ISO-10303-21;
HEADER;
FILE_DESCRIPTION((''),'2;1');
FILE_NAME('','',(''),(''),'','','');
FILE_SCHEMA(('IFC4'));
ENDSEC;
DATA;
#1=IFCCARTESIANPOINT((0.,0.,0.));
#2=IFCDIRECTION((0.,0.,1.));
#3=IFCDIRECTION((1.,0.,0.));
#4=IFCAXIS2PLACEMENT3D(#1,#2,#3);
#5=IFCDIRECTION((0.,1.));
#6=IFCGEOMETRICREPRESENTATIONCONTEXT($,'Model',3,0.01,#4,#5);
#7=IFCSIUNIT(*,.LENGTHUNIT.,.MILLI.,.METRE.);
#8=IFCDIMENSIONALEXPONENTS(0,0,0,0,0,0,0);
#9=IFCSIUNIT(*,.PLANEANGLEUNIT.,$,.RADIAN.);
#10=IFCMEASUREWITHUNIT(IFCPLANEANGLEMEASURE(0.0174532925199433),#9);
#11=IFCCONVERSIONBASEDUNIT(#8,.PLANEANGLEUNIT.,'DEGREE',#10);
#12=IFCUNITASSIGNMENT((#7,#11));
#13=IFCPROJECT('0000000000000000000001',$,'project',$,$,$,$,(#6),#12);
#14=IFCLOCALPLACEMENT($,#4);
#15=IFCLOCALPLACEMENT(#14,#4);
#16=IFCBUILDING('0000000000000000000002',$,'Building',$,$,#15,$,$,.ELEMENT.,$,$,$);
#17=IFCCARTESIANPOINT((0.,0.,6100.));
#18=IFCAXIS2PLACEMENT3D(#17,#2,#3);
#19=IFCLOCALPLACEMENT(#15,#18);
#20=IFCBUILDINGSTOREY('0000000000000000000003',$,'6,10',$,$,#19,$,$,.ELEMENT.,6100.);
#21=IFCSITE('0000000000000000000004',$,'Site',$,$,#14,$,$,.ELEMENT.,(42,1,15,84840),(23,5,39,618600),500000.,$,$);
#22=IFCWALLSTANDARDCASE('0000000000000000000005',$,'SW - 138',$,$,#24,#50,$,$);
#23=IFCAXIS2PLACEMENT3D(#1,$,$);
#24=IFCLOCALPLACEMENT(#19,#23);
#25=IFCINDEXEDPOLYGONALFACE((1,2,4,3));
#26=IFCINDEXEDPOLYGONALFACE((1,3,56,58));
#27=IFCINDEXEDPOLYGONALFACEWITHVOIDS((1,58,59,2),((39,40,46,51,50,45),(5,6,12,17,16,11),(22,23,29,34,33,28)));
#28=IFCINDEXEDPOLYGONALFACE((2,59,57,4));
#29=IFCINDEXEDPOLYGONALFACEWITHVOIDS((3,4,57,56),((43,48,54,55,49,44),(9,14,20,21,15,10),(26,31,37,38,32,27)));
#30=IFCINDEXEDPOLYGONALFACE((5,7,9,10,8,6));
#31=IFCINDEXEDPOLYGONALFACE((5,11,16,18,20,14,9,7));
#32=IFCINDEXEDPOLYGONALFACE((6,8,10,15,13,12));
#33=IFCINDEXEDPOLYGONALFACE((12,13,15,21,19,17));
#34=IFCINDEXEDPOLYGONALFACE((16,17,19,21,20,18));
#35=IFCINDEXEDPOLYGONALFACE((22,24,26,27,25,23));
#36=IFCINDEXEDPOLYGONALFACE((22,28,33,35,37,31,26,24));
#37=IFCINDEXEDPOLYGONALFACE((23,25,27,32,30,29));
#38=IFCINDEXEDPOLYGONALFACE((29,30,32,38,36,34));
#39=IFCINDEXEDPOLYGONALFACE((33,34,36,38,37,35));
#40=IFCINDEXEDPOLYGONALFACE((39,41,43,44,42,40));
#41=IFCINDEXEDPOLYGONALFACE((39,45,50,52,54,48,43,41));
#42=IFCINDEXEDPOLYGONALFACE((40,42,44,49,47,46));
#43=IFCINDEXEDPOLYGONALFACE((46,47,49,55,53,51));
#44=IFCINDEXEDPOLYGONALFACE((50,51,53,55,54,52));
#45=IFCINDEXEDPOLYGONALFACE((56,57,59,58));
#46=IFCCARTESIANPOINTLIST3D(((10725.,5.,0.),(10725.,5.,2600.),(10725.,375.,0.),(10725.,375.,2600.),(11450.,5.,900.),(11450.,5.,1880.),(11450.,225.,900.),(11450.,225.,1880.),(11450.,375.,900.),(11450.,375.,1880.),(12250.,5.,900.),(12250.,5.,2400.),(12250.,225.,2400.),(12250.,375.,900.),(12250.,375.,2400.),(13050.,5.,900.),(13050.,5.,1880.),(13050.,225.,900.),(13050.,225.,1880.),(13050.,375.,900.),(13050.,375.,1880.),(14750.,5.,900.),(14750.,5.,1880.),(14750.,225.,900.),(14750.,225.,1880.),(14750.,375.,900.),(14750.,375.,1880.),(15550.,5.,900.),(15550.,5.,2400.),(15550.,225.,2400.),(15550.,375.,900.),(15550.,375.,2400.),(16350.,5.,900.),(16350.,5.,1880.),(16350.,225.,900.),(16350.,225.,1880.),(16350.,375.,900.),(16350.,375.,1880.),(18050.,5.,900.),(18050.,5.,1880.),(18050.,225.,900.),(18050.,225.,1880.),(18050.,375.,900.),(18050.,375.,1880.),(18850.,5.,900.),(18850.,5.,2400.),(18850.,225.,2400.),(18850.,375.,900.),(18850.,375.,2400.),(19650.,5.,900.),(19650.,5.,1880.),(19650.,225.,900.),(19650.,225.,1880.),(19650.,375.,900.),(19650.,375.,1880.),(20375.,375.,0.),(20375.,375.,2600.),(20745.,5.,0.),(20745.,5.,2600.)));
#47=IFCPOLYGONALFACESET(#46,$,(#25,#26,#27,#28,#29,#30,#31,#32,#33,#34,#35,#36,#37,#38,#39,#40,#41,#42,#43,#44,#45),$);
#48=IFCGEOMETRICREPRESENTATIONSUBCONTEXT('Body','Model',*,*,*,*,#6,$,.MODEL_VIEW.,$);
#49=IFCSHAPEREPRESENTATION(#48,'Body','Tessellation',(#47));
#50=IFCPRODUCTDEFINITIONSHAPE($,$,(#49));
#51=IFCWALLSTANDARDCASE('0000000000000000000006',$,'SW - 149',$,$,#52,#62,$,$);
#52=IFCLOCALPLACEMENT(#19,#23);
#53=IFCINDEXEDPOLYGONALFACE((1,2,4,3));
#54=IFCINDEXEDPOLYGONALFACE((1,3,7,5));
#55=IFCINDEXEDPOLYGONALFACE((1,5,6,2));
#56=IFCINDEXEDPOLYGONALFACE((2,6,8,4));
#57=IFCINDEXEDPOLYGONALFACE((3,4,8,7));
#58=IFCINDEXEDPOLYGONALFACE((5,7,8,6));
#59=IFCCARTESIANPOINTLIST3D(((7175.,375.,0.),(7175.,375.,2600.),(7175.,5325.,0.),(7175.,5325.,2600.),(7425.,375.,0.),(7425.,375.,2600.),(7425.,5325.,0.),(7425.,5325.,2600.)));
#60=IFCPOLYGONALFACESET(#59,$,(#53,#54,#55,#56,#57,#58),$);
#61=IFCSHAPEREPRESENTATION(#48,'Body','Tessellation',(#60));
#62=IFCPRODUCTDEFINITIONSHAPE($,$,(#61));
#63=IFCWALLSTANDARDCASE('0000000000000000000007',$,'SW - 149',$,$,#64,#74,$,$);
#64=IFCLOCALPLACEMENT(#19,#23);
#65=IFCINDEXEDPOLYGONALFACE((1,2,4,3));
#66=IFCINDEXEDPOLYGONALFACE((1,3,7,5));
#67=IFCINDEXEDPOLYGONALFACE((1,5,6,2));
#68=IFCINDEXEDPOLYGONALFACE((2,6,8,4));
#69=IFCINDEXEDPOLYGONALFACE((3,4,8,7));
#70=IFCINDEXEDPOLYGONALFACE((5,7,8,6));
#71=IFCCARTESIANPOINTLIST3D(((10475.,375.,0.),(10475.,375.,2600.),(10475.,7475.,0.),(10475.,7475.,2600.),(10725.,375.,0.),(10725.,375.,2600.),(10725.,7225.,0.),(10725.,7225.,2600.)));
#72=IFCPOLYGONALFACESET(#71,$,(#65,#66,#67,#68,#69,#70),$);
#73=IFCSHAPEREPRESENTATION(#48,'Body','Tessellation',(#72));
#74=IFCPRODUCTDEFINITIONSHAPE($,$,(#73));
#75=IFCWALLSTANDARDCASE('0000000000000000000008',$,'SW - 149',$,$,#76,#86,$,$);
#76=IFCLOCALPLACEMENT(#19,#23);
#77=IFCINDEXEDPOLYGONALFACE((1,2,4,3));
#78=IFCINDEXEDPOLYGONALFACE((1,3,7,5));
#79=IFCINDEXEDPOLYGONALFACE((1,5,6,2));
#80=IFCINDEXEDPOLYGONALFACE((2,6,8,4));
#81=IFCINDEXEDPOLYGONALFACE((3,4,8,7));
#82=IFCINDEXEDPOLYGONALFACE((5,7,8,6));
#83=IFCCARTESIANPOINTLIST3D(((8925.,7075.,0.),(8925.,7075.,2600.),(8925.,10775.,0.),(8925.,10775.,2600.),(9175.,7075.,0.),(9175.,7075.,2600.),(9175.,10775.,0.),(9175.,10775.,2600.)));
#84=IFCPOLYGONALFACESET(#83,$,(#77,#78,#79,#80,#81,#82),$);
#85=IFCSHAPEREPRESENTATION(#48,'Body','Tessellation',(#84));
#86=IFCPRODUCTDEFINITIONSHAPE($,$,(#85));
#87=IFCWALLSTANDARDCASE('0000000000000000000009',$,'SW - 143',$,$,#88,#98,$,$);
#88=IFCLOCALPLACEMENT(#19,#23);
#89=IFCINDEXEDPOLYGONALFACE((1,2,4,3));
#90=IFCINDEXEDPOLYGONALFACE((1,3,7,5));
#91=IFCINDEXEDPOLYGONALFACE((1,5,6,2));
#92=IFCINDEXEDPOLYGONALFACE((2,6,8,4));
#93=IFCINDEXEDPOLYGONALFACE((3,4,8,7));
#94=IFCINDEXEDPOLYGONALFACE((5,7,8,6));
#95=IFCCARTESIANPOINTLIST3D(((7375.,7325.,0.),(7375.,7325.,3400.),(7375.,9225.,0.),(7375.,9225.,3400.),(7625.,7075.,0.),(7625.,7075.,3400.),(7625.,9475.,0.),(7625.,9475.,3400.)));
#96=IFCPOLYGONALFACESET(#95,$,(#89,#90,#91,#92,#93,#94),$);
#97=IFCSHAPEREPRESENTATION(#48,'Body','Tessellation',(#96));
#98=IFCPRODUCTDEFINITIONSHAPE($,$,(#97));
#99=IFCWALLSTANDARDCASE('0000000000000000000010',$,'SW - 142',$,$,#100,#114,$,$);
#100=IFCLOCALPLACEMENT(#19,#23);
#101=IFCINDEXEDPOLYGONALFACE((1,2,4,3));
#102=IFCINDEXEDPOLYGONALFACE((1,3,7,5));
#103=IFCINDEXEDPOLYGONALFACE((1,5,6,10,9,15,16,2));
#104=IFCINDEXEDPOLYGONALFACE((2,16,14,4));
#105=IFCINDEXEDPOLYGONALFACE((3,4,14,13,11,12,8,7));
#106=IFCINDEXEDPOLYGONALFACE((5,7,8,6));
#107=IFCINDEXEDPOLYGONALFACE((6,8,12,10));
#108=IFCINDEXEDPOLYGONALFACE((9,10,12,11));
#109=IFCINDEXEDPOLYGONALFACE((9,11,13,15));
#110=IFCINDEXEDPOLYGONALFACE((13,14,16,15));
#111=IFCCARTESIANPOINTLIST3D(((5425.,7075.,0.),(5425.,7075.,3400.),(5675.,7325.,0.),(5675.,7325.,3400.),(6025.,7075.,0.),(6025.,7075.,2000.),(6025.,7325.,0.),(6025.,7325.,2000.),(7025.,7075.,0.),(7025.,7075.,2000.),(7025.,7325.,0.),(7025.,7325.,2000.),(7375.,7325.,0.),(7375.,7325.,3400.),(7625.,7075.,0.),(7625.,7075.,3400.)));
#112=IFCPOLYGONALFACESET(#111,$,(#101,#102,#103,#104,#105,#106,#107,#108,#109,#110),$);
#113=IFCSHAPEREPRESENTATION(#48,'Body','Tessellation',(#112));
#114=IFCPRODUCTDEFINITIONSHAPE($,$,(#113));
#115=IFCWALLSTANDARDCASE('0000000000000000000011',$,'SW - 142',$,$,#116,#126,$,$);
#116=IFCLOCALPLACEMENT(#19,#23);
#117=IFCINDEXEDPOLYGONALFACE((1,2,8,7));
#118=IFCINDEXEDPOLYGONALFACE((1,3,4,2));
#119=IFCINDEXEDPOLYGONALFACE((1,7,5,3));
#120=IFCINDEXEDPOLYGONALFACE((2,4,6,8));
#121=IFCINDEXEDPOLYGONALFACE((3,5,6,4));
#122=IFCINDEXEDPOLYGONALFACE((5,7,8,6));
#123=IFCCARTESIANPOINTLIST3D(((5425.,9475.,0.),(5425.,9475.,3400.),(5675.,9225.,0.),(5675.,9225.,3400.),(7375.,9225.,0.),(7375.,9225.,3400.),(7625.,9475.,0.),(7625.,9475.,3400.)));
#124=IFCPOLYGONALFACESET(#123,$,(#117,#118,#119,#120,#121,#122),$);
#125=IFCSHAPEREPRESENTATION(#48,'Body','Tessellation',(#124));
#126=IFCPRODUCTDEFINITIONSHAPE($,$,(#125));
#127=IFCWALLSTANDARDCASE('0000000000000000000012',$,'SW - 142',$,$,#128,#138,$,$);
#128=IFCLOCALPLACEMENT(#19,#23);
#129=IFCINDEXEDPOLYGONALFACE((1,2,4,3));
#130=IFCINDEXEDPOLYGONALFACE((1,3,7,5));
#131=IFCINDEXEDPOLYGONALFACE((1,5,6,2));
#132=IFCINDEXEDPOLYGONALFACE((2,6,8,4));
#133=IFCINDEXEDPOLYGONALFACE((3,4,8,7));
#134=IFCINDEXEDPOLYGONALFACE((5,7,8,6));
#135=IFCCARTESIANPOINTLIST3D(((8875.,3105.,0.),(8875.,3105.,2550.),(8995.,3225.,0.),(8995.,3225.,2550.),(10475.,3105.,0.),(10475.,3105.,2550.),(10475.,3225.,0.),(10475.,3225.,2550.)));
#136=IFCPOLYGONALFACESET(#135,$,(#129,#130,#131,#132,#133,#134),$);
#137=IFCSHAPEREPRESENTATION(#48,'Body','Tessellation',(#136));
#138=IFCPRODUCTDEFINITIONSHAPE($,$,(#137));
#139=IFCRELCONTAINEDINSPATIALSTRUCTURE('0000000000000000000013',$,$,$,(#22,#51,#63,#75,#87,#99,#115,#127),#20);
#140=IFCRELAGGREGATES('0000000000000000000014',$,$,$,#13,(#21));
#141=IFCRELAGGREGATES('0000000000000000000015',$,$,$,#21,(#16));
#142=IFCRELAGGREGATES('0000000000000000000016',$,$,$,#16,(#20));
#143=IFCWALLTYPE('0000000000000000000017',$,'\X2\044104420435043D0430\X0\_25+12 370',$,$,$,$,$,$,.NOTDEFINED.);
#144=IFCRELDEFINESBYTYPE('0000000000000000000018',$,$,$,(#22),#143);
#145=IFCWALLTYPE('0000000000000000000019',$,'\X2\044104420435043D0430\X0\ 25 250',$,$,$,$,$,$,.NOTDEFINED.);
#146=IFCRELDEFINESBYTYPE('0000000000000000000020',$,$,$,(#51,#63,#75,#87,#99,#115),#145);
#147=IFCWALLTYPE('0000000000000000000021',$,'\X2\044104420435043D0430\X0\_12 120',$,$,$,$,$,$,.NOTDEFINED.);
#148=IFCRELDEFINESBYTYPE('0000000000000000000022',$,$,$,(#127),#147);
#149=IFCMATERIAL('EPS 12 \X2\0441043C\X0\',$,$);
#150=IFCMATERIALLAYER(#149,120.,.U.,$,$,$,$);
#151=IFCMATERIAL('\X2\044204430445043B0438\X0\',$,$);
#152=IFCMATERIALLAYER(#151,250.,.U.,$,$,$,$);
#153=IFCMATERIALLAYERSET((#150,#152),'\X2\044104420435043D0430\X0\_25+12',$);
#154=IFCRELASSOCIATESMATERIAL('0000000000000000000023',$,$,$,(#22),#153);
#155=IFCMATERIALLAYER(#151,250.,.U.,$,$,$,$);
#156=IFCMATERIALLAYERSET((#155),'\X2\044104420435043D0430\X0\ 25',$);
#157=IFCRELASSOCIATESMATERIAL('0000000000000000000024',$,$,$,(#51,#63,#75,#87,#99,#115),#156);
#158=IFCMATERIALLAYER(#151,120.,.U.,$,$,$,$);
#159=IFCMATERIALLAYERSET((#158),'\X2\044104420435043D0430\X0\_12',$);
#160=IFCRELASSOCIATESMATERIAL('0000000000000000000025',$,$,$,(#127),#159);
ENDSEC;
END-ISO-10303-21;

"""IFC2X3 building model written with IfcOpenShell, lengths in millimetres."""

from ifc_helpers import new_model, entity, si_unit, converted_unit, direction, frame, origin_with_axes, origin_2d_with_axis, place, context, subcontext, project, spatial, polyline, rectangle, outline, extrude, material, layer, layer_set, layer_usage, type_object, element, save


model = new_model("IFC2X3")

# Units and contexts
model_context = context("Model", 3, precision=0.01, world=origin_with_axes(), true_north=direction((0.0, 1.0)))
body_context = subcontext(model_context, "Body", "Model", "MODEL_VIEW")
ifc_project = project(units=[si_unit("LENGTHUNIT", "METRE", prefix="MILLI"), converted_unit("PLANEANGLEUNIT", "DEGREE", entity("IfcPlaneAngleMeasure", 0.0174532925199433), si_unit("PLANEANGLEUNIT", "RADIAN"), dimensions=[0, 0, 0, 0, 0, 0, 0])], contexts=[model_context])

# Site, building, storey
site_placement = place(None, origin_with_axes())
site = spatial("IfcSite", under=ifc_project, at=site_placement, Name="Site", CompositionType="ELEMENT", RefLatitude=(42, 1, 15, 84840), RefLongitude=(23, 5, 39, 618600), RefElevation=500000.0)
building_placement = place(site_placement, origin_with_axes())
building = spatial("IfcBuilding", under=site, at=building_placement, Name="Building", CompositionType="ELEMENT")
storey_placement = place(building_placement, frame((0.0, 0.0, 6100.0), z_axis=(0.0, 0.0, 1.0), x_axis=(1.0, 0.0, 0.0)))
storey = spatial("IfcBuildingStorey", under=building, at=storey_placement, Name="6,10", CompositionType="ELEMENT", Elevation=6100.0)

# Wall, openings
ifc_material_1 = material(Name="EPS 12 см")
ifc_layer_1 = layer(ifc_material_1, 120.0, ventilated="UNKNOWN")
ifc_material_2 = material(Name="тухли")
ifc_layer_2 = layer(ifc_material_2, 250.0, ventilated="UNKNOWN")
ifc_layer_set_1 = layer_set([ifc_layer_1, ifc_layer_2], Name="стена_25+12")
ifc_layer_usage_1 = layer_usage(ifc_layer_set_1, "AXIS2", "POSITIVE", -120.0)
wall_type_1 = type_object("IfcWallType", Name="стена_25+12 370", PredefinedType="NOTDEFINED")
wall_1_placement = place(storey_placement, frame((10725.0, 125.0, 0.0), z_axis=(0.0, 0.0, 1.0), x_axis=(1.0, 0.0, 0.0)))
wall_1 = element("IfcWallStandardCase", 1, at=wall_1_placement, inside=storey, type_object=wall_type_1, material=ifc_layer_usage_1, Name="SW - 138", context=body_context, shape_type="SweptSolid", body=[
    extrude(outline(polyline([(0.0, -120.0), (10020.0, -120.0), (9650.0, 250.0), (0.0, 250.0), (0.0, -120.0)])), origin_with_axes(), (0.0, 0.0, 1.0), 2600.0),
])
opening_1_placement = place(wall_1_placement, frame((1925.0, 0.0, 900.0), z_axis=(0.0, 0.0, 1.0), x_axis=(1.0, 0.0, 0.0)))
element("IfcOpeningElement", 2, at=opening_1_placement, cuts=wall_1, context=body_context, shape_type="SweptSolid", body=[
    extrude(outline(polyline([(-400.0, 0.0), (-400.0, -1500.0), (400.0, -980.0), (400.0, 0.0), (-400.0, 0.0)])), frame((0.0, 100.0, 0.0), z_axis=(0.0, 1.0, 0.0), x_axis=(1.0, 0.0, 0.0)), (0.0, 0.0, -1.0), 590.0),
    extrude(outline(polyline([(400.0, 0.0), (400.0, 980.0), (-400.0, 1500.0), (-400.0, 0.0), (400.0, 0.0)])), frame((0.0, 100.0, 0.0), z_axis=(0.0, -1.0, 0.0), x_axis=(1.0, 0.0, 0.0)), (0.0, 0.0, -1.0), 520.0),
])
opening_2_placement = place(wall_1_placement, frame((5225.0, 0.0, 900.0), z_axis=(0.0, 0.0, 1.0), x_axis=(1.0, 0.0, 0.0)))
element("IfcOpeningElement", 3, at=opening_2_placement, cuts=wall_1, context=body_context, shape_type="SweptSolid", body=[
    extrude(outline(polyline([(-400.0, 0.0), (-400.0, -1500.0), (400.0, -980.0), (400.0, 0.0), (-400.0, 0.0)])), frame((0.0, 100.0, 0.0), z_axis=(0.0, 1.0, 0.0), x_axis=(1.0, 0.0, 0.0)), (0.0, 0.0, -1.0), 590.0),
    extrude(outline(polyline([(400.0, 0.0), (400.0, 980.0), (-400.0, 1500.0), (-400.0, 0.0), (400.0, 0.0)])), frame((0.0, 100.0, 0.0), z_axis=(0.0, -1.0, 0.0), x_axis=(1.0, 0.0, 0.0)), (0.0, 0.0, -1.0), 520.0),
])
opening_3_placement = place(wall_1_placement, frame((1125.0, 0.0, 900.0), z_axis=(0.0, 0.0, 1.0), x_axis=(1.0, 0.0, 0.0)))
element("IfcOpeningElement", 4, at=opening_3_placement, cuts=wall_1, context=body_context, shape_type="SweptSolid", body=[
    extrude(outline(polyline([(-400.0, 0.0), (-400.0, -1500.0), (400.0, -980.0), (400.0, 0.0), (-400.0, 0.0)])), frame((0.0, 100.0, 0.0), z_axis=(0.0, -1.0, 0.0), x_axis=(-1.0, 0.0, 0.0)), (0.0, 0.0, 1.0), 590.0),
    extrude(outline(polyline([(400.0, 0.0), (400.0, 980.0), (-400.0, 1500.0), (-400.0, 0.0), (400.0, 0.0)])), frame((0.0, 100.0, 0.0), z_axis=(0.0, 1.0, 0.0), x_axis=(-1.0, 0.0, 0.0)), (0.0, 0.0, 1.0), 520.0),
])
opening_4_placement = place(wall_1_placement, frame((4425.0, 0.0, 900.0), z_axis=(0.0, 0.0, 1.0), x_axis=(1.0, 0.0, 0.0)))
element("IfcOpeningElement", 5, at=opening_4_placement, cuts=wall_1, context=body_context, shape_type="SweptSolid", body=[
    extrude(outline(polyline([(-400.0, 0.0), (-400.0, -1500.0), (400.0, -980.0), (400.0, 0.0), (-400.0, 0.0)])), frame((0.0, 100.0, 0.0), z_axis=(0.0, -1.0, 0.0), x_axis=(-1.0, 0.0, 0.0)), (0.0, 0.0, 1.0), 590.0),
    extrude(outline(polyline([(400.0, 0.0), (400.0, 980.0), (-400.0, 1500.0), (-400.0, 0.0), (400.0, 0.0)])), frame((0.0, 100.0, 0.0), z_axis=(0.0, 1.0, 0.0), x_axis=(-1.0, 0.0, 0.0)), (0.0, 0.0, 1.0), 520.0),
])
opening_5_placement = place(wall_1_placement, frame((8525.0, 0.0, 900.0), z_axis=(0.0, 0.0, 1.0), x_axis=(1.0, 0.0, 0.0)))
element("IfcOpeningElement", 6, at=opening_5_placement, cuts=wall_1, context=body_context, shape_type="SweptSolid", body=[
    extrude(outline(polyline([(-400.0, 0.0), (-400.0, -1500.0), (400.0, -980.0), (400.0, 0.0), (-400.0, 0.0)])), frame((0.0, 100.0, 0.0), z_axis=(0.0, 1.0, 0.0), x_axis=(1.0, 0.0, 0.0)), (0.0, 0.0, -1.0), 590.0),
    extrude(outline(polyline([(400.0, 0.0), (400.0, 980.0), (-400.0, 1500.0), (-400.0, 0.0), (400.0, 0.0)])), frame((0.0, 100.0, 0.0), z_axis=(0.0, -1.0, 0.0), x_axis=(1.0, 0.0, 0.0)), (0.0, 0.0, -1.0), 520.0),
])
opening_6_placement = place(wall_1_placement, frame((7725.0, 0.0, 900.0), z_axis=(0.0, 0.0, 1.0), x_axis=(1.0, 0.0, 0.0)))
element("IfcOpeningElement", 7, at=opening_6_placement, cuts=wall_1, context=body_context, shape_type="SweptSolid", body=[
    extrude(outline(polyline([(-400.0, 0.0), (-400.0, -1500.0), (400.0, -980.0), (400.0, 0.0), (-400.0, 0.0)])), frame((0.0, 100.0, 0.0), z_axis=(0.0, -1.0, 0.0), x_axis=(-1.0, 0.0, 0.0)), (0.0, 0.0, 1.0), 590.0),
    extrude(outline(polyline([(400.0, 0.0), (400.0, 980.0), (-400.0, 1500.0), (-400.0, 0.0), (400.0, 0.0)])), frame((0.0, 100.0, 0.0), z_axis=(0.0, 1.0, 0.0), x_axis=(-1.0, 0.0, 0.0)), (0.0, 0.0, 1.0), 520.0),
])

# Walls
ifc_layer_3 = layer(ifc_material_2, 250.0, ventilated="UNKNOWN")
ifc_layer_set_2 = layer_set([ifc_layer_3], Name="стена 25")
ifc_layer_usage_2 = layer_usage(ifc_layer_set_2, "AXIS2", "NEGATIVE", 0.0)
wall_type_2 = type_object("IfcWallType", Name="стена 25 250", PredefinedType="NOTDEFINED")
wall_2_placement = place(storey_placement, frame((7175.0, 125.0, 0.0), z_axis=(0.0, 0.0, 1.0), x_axis=(0.0, 1.0, 0.0)))
element("IfcWallStandardCase", 8, at=wall_2_placement, inside=storey, type_object=wall_type_2, material=ifc_layer_usage_2, Name="SW - 149", context=body_context, shape_type="SweptSolid", body=[
    extrude(outline(polyline([(250.0, -250.0), (5200.0, -250.0), (5200.0, 0.0), (250.0, 0.0), (250.0, -250.0)])), origin_with_axes(), (0.0, 0.0, 1.0), 2600.0),
])
ifc_layer_usage_3 = layer_usage(ifc_layer_set_2, "AXIS2", "NEGATIVE", 0.0)
wall_3_placement = place(storey_placement, frame((10475.0, 125.0, 0.0), z_axis=(0.0, 0.0, 1.0), x_axis=(0.0, 1.0, 0.0)))
element("IfcWallStandardCase", 9, at=wall_3_placement, inside=storey, type_object=wall_type_2, material=ifc_layer_usage_3, Name="SW - 149", context=body_context, shape_type="SweptSolid", body=[
    extrude(outline(polyline([(250.0, -250.0), (7100.0, -250.0), (7350.0, 0.0), (250.0, 0.0), (250.0, -250.0)])), origin_with_axes(), (0.0, 0.0, 1.0), 2600.0),
])
ifc_layer_usage_4 = layer_usage(ifc_layer_set_2, "AXIS2", "NEGATIVE", 0.0)
wall_4_placement = place(storey_placement, frame((8925.0, 7075.0, 0.0), z_axis=(0.0, 0.0, 1.0), x_axis=(0.0, 1.0, 0.0)))
element("IfcWallStandardCase", 10, at=wall_4_placement, inside=storey, type_object=wall_type_2, material=ifc_layer_usage_4, Name="SW - 149", context=body_context, shape_type="SweptSolid", body=[
    extrude(outline(polyline([(0.0, -250.0), (3700.0, -250.0), (3700.0, 0.0), (0.0, 0.0), (0.0, -250.0)])), origin_with_axes(), (0.0, 0.0, 1.0), 2600.0),
])
ifc_layer_usage_5 = layer_usage(ifc_layer_set_2, "AXIS2", "NEGATIVE", 0.0)
wall_5_placement = place(storey_placement, frame((7625.0, 9475.0, 0.0), z_axis=(0.0, 0.0, 1.0), x_axis=(0.0, -1.0, 0.0)))
element("IfcWallStandardCase", 11, at=wall_5_placement, inside=storey, type_object=wall_type_2, material=ifc_layer_usage_5, Name="SW - 143", context=body_context, shape_type="SweptSolid", body=[
    extrude(outline(polyline([(250.0, -250.0), (2150.0, -250.0), (2400.0, 0.0), (0.0, 0.0), (250.0, -250.0)])), origin_with_axes(), (0.0, 0.0, 1.0), 3400.0),
])

# Wall, opening
ifc_layer_usage_6 = layer_usage(ifc_layer_set_2, "AXIS2", "NEGATIVE", 0.0)
wall_6_placement = place(storey_placement, frame((7625.0, 7075.0, 0.0), z_axis=(0.0, 0.0, 1.0), x_axis=(-1.0, 0.0, 0.0)))
wall_6 = element("IfcWallStandardCase", 12, at=wall_6_placement, inside=storey, type_object=wall_type_2, material=ifc_layer_usage_6, Name="SW - 142", context=body_context, shape_type="SweptSolid", body=[
    extrude(outline(polyline([(250.0, -250.0), (1950.0, -250.0), (2200.0, 0.0), (0.0, 0.0), (250.0, -250.0)])), origin_with_axes(), (0.0, 0.0, 1.0), 3400.0),
])
opening_7_placement = place(wall_6_placement, frame((1100.0, 0.0, 0.0), z_axis=(0.0, 0.0, 1.0), x_axis=(1.0, 0.0, 0.0)))
element("IfcOpeningElement", 13, at=opening_7_placement, cuts=wall_6, context=body_context, shape_type="SweptSolid", body=[
    extrude(rectangle(XDim=1000.0, YDim=2000.0, at=origin_2d_with_axis()), frame((0.0, -250.0, 1000.0), z_axis=(0.0, 1.0, 0.0), x_axis=(-1.0, 0.0, 0.0)), (0.0, 0.0, 1.0), 750.0),
])

# Walls
ifc_layer_usage_7 = layer_usage(ifc_layer_set_2, "AXIS2", "POSITIVE", 0.0)
wall_7_placement = place(storey_placement, frame((7625.0, 9475.0, 0.0), z_axis=(0.0, 0.0, 1.0), x_axis=(-1.0, 0.0, 0.0)))
element("IfcWallStandardCase", 14, at=wall_7_placement, inside=storey, type_object=wall_type_2, material=ifc_layer_usage_7, Name="SW - 142", context=body_context, shape_type="SweptSolid", body=[
    extrude(outline(polyline([(0.0, 0.0), (2200.0, 0.0), (1950.0, 250.0), (250.0, 250.0), (0.0, 0.0)])), origin_with_axes(), (0.0, 0.0, 1.0), 3400.0),
])
ifc_layer_4 = layer(ifc_material_2, 120.0, ventilated="UNKNOWN")
ifc_layer_set_3 = layer_set([ifc_layer_4], Name="стена_12")
ifc_layer_usage_8 = layer_usage(ifc_layer_set_3, "AXIS2", "POSITIVE", -60.0)
wall_type_3 = type_object("IfcWallType", Name="стена_12 120", PredefinedType="NOTDEFINED")
wall_8_placement = place(storey_placement, frame((10475.0, 3165.0, 0.0), z_axis=(0.0, 0.0, 1.0), x_axis=(-1.0, 0.0, 0.0)))
element("IfcWallStandardCase", 15, at=wall_8_placement, inside=storey, type_object=wall_type_3, material=ifc_layer_usage_8, Name="SW - 142", context=body_context, shape_type="SweptSolid", body=[
    extrude(outline(polyline([(0.0, -60.0), (1480.0, -60.0), (1600.0, 60.0), (0.0, 60.0), (0.0, -60.0)])), origin_with_axes(), (0.0, 0.0, 1.0), 2550.0),
])

save(model, "model.ifc")
